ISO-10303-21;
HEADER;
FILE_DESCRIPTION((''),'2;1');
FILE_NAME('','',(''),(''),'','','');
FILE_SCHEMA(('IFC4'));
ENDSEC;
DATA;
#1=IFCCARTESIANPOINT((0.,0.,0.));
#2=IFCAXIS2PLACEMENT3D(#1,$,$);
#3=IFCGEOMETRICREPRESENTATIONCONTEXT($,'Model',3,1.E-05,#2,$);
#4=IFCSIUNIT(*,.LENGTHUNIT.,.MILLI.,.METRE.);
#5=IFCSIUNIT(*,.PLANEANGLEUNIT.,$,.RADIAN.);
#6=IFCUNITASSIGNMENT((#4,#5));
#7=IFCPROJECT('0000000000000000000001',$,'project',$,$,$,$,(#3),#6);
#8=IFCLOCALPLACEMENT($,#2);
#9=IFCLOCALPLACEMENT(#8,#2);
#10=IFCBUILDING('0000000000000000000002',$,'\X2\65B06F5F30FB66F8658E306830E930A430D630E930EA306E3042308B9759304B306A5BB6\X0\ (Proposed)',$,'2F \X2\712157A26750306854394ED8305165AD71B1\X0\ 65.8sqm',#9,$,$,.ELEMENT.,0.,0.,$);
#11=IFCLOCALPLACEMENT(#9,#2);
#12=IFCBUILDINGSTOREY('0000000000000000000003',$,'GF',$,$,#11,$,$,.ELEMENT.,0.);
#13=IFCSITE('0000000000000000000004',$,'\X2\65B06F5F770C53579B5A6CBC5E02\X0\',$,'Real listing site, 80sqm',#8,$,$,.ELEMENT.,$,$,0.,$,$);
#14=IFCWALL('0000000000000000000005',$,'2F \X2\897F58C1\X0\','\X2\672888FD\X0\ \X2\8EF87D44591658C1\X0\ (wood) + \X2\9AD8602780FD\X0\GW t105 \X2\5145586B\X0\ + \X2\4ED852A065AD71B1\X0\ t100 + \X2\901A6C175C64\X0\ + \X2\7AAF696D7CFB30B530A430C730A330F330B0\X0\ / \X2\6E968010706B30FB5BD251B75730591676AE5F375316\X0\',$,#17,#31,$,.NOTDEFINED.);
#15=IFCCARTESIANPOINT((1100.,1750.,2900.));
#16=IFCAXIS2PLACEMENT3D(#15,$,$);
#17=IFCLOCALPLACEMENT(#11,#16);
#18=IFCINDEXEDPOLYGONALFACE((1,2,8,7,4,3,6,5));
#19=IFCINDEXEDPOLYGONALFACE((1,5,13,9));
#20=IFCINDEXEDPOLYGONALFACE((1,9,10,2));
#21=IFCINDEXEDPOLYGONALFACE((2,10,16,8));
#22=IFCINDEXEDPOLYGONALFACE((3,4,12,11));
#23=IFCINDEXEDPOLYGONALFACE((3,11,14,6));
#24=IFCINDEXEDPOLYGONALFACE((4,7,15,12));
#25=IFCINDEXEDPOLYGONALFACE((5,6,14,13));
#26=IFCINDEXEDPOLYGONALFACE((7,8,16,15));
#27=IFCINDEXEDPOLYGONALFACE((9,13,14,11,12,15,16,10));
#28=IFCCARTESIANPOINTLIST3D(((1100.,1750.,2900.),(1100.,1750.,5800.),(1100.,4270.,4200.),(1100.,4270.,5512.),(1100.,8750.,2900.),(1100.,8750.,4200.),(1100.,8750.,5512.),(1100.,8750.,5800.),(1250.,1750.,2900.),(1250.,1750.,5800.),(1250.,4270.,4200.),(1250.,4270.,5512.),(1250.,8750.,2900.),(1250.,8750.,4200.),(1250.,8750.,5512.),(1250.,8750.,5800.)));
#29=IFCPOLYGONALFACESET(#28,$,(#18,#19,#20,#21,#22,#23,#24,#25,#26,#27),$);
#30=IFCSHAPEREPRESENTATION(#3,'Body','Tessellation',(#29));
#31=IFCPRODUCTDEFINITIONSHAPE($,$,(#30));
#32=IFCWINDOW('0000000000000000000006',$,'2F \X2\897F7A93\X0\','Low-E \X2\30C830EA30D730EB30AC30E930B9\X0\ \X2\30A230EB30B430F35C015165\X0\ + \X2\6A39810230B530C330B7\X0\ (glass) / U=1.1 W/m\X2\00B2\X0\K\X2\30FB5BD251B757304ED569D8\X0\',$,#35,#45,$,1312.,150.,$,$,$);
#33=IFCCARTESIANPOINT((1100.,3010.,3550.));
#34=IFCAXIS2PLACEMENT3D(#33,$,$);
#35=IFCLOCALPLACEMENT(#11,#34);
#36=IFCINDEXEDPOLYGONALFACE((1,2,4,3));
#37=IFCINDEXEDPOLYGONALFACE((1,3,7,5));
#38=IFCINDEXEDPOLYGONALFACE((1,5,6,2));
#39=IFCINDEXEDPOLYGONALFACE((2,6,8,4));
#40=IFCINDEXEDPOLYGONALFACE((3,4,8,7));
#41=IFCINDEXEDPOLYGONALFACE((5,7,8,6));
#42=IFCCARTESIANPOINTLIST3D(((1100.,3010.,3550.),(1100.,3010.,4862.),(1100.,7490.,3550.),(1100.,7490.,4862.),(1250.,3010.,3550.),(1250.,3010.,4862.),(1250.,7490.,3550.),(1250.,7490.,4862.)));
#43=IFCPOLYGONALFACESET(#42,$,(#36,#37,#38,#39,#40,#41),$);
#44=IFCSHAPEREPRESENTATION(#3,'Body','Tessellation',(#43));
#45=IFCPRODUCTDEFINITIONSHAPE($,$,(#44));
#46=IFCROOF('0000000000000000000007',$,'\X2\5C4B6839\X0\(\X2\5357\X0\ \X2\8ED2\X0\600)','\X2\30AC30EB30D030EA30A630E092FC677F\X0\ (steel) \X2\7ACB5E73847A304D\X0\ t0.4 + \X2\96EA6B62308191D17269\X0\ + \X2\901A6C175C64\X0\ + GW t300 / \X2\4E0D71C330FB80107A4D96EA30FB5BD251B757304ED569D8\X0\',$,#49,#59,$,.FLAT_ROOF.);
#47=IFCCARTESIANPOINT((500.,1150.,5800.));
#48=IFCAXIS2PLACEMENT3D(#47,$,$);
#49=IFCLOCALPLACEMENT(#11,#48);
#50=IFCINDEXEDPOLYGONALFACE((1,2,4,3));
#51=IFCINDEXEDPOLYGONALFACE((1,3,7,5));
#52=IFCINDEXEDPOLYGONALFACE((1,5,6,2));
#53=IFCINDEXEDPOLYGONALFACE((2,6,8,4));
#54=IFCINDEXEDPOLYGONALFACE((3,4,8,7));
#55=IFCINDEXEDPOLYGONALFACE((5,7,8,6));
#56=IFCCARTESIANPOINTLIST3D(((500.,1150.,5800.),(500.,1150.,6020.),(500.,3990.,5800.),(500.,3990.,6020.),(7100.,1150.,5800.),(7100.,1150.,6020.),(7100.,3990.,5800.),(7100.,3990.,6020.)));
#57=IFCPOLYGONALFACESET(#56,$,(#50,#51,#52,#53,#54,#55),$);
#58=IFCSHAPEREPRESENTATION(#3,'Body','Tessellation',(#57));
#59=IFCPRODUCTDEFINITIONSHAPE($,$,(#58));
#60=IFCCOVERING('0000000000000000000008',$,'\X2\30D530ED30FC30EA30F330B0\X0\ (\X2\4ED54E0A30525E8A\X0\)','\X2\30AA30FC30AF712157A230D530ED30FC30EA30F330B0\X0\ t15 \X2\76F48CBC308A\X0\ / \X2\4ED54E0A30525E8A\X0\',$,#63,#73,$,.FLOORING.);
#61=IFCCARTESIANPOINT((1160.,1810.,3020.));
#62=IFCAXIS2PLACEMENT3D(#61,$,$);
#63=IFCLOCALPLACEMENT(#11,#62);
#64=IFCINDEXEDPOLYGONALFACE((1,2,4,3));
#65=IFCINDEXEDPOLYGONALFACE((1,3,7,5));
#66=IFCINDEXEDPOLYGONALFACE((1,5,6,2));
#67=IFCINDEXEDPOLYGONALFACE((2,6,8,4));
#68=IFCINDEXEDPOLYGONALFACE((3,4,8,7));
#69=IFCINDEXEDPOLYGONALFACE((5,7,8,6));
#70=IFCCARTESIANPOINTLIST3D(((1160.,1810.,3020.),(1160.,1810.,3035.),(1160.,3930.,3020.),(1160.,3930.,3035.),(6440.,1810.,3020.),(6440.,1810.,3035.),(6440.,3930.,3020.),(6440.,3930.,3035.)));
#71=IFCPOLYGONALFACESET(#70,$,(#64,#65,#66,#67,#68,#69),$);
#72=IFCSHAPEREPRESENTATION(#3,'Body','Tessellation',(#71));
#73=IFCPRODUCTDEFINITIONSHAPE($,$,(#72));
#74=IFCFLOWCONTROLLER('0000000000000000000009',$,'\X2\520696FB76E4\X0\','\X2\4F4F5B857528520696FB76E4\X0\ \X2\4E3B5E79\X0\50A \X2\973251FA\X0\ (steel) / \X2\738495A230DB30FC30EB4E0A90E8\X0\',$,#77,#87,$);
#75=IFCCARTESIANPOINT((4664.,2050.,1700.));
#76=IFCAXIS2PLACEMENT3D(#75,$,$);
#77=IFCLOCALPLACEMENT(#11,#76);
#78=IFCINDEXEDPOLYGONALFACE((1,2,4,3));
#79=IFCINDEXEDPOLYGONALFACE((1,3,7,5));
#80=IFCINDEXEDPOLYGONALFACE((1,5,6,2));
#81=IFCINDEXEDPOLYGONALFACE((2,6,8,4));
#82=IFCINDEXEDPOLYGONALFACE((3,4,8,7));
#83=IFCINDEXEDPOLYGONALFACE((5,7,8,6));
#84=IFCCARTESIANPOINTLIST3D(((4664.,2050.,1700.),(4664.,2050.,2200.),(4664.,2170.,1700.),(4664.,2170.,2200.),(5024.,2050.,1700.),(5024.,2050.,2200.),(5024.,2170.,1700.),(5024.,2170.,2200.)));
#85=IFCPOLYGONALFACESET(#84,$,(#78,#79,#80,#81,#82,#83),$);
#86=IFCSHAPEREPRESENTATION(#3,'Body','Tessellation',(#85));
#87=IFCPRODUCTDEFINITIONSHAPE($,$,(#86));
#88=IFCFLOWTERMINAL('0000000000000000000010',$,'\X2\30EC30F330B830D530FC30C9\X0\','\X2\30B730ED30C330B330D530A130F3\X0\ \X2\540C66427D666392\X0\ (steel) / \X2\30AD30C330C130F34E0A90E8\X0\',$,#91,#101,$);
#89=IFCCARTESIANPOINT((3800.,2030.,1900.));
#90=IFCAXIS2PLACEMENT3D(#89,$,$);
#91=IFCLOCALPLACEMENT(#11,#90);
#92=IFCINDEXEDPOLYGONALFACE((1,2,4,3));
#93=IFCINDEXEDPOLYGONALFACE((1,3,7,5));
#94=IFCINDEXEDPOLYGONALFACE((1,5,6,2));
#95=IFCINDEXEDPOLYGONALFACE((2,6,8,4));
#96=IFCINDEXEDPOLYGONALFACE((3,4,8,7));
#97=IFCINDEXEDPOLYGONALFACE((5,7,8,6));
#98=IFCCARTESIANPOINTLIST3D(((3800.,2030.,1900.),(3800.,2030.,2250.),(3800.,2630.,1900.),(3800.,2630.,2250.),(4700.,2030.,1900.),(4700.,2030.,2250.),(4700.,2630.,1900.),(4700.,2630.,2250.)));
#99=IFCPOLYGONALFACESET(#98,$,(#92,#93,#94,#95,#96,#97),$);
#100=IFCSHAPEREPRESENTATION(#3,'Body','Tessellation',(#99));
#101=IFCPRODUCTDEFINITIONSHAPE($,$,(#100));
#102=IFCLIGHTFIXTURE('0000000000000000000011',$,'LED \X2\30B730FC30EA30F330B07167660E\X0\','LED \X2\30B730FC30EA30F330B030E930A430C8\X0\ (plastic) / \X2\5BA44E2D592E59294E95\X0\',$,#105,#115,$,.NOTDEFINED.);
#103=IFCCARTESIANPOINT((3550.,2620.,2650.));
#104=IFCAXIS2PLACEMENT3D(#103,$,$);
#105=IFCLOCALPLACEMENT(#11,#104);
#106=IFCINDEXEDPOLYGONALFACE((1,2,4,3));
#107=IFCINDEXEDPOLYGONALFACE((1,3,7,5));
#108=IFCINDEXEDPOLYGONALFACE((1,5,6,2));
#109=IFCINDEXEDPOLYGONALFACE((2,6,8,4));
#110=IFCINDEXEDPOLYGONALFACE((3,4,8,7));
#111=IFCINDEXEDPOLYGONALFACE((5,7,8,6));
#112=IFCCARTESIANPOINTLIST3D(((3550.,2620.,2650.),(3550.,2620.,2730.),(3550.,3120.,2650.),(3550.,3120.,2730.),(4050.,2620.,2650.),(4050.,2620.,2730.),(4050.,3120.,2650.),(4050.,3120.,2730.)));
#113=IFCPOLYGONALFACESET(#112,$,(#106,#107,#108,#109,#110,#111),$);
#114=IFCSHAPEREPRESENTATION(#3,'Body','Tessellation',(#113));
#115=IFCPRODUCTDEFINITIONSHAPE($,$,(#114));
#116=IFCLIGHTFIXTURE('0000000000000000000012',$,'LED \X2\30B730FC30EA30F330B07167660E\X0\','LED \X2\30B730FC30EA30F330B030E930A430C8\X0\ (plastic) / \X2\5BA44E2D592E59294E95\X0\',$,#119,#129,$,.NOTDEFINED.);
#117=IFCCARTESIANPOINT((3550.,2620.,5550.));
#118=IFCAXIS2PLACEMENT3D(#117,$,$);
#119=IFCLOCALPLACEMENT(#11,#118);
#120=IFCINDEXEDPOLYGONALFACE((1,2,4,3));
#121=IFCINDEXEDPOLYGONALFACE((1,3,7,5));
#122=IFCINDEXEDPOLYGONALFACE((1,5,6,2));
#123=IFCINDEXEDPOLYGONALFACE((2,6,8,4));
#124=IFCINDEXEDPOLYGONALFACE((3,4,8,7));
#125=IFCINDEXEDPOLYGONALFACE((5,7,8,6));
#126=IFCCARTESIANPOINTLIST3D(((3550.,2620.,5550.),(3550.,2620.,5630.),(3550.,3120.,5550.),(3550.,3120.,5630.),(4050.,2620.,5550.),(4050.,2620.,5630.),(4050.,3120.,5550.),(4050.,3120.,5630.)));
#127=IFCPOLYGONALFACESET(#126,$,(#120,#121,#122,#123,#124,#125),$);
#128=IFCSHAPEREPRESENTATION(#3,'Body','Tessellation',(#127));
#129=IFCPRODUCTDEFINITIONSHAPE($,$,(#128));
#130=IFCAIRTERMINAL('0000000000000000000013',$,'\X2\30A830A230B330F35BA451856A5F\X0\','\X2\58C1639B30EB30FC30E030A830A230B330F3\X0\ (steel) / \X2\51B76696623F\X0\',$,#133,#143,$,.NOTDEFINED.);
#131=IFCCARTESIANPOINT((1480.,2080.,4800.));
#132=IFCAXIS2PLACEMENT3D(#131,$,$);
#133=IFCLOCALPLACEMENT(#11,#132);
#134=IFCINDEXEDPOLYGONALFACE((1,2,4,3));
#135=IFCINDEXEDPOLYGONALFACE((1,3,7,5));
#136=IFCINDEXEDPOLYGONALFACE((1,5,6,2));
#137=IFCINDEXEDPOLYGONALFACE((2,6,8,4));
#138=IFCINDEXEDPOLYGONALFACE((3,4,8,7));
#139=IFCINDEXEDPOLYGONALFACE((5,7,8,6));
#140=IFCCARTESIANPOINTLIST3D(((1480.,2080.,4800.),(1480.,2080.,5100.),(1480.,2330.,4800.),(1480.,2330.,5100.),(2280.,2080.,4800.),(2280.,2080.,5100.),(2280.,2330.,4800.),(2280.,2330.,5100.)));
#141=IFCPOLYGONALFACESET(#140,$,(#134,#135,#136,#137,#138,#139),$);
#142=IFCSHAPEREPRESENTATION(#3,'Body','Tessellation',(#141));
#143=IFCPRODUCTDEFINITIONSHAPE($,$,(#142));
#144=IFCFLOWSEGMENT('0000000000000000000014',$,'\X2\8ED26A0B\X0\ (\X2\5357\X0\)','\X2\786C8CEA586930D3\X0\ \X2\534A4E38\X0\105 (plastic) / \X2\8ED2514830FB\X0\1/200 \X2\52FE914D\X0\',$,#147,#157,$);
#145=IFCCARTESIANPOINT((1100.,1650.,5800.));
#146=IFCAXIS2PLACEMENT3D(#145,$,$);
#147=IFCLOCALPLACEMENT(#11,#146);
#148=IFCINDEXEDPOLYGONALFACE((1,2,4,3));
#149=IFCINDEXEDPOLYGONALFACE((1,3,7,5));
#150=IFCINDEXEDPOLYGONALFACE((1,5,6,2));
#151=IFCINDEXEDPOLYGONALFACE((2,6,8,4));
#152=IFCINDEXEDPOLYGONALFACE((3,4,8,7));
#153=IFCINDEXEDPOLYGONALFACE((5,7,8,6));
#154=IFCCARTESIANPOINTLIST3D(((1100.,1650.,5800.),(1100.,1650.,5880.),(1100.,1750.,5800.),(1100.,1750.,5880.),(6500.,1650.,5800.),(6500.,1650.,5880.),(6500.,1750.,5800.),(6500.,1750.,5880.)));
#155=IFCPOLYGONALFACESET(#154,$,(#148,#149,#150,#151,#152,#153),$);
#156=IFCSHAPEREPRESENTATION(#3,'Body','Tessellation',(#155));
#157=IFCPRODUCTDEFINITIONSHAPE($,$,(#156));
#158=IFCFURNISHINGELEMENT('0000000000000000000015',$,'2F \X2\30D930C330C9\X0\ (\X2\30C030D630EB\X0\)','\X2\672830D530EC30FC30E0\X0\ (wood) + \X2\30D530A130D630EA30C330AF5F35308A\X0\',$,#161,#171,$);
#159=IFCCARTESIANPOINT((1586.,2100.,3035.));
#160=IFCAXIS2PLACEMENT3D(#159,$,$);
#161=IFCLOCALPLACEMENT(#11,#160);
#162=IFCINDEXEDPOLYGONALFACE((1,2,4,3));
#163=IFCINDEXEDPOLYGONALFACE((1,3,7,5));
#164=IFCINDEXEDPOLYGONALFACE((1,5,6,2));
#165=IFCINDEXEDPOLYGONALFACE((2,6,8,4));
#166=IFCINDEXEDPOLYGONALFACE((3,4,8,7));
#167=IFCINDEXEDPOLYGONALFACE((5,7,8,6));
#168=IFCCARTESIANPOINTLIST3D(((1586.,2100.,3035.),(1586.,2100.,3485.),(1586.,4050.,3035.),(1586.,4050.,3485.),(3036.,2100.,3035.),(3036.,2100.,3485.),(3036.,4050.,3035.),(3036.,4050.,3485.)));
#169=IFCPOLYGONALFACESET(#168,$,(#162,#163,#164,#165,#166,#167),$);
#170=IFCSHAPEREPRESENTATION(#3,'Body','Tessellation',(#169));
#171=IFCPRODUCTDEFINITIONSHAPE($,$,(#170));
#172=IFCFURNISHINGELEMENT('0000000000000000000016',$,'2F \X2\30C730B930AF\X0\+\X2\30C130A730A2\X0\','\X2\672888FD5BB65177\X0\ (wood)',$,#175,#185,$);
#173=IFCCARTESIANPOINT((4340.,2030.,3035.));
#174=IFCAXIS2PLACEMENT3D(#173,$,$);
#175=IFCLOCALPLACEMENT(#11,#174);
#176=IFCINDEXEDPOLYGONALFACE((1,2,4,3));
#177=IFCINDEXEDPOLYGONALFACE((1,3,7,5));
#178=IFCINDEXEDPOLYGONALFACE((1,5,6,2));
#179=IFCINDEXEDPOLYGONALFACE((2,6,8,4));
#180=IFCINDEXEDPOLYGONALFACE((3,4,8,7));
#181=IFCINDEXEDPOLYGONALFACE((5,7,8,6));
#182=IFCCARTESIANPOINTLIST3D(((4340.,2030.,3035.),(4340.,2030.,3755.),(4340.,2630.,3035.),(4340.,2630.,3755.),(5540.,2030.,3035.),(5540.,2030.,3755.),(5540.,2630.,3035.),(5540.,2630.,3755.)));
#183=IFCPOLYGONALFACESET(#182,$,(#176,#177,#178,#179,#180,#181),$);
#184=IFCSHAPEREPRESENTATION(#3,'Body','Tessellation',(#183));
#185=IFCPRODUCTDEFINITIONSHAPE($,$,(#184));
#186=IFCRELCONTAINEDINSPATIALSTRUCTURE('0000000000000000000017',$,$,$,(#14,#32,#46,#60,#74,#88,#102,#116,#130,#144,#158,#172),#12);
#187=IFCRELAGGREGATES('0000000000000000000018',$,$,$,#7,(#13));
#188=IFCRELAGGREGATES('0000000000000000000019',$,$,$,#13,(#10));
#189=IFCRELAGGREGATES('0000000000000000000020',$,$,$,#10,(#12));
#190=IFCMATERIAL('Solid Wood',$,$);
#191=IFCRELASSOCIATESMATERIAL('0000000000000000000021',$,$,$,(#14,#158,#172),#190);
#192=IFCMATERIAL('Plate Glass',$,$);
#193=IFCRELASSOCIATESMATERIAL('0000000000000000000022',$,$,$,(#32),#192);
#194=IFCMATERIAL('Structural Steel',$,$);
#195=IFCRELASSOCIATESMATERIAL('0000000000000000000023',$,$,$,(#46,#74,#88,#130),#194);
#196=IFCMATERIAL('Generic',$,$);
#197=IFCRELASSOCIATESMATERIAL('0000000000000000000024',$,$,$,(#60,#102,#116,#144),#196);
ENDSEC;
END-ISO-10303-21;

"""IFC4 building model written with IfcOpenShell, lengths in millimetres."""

from ifc_helpers import new_model, si_unit, frame, frame_2d, origin, place, context, project, spatial, rectangle, extrude, material, element, fill, save


model = new_model("IFC4")

# Units and contexts
model_context = context("Model", 3, precision=1e-05, world=origin())
ifc_project = project(units=[si_unit("LENGTHUNIT", "METRE", prefix="MILLI"), si_unit("PLANEANGLEUNIT", "RADIAN")], contexts=[model_context])

# Site, building, storey
site_placement = place(None, origin())
site = spatial("IfcSite", under=ifc_project, at=site_placement, Name="新潟県南魚沼市", ObjectType="Real listing site, 80sqm", CompositionType="ELEMENT", RefElevation=0.0)
building_placement = place(site_placement, origin())
building = spatial("IfcBuilding", under=site, at=building_placement, Name="新潟・書斎とライブラリのある静かな家 (Proposed)", ObjectType="2F 無垢材と吹付け断熱 65.8sqm", CompositionType="ELEMENT", ElevationOfRefHeight=0.0, ElevationOfTerrain=0.0)
storey_placement = place(building_placement, origin())
storey = spatial("IfcBuildingStorey", under=building, at=storey_placement, Name="GF", CompositionType="ELEMENT", Elevation=0.0)

# Shared definitions
ifc_material_1 = material(Name="Solid Wood")

# Wall, opening, window
ifc_material_2 = material(Name="Plate Glass")
wall_1_placement = place(storey_placement, frame((1100.0, 1750.0, 2900.0)))
wall_1 = element("IfcWall", 1, at=wall_1_placement, inside=storey, material=ifc_material_1, Name="2F 西壁", Description="木製 軸組外壁 (wood) + 高性能GW t105 充填 + 付加断熱 t100 + 通気層 + 窯業系サイディング / 準耐火・寒冷地外皮強化", PredefinedType="NOTDEFINED", context=model_context, shape_type="SweptSolid", body=[
    extrude(rectangle(XDim=150.0, YDim=7000.0, at=frame_2d((75.0, 3500.0))), frame((1100.0, 1750.0, 2900.0)), (0.0, 0.0, 1.0), 2900.0),
])
opening_1_placement = place(storey_placement, frame((1100.0, 3010.0, 3550.0)))
opening_1 = element("IfcOpeningElement", 2, at=opening_1_placement, cuts=wall_1, PredefinedType="NOTDEFINED", context=model_context, shape_type="SweptSolid", body=[
    extrude(rectangle(XDim=150.0, YDim=4480.0, at=frame_2d((75.0, 2240.0))), frame((1100.0, 3010.0, 3550.0)), (0.0, 0.0, 1.0), 1312.0),
])
window_1_placement = place(storey_placement, frame((1100.0, 3010.0, 3550.0)))
window_1 = element("IfcWindow", 3, at=window_1_placement, inside=storey, material=ifc_material_2, Name="2F 西窓", Description="Low-E トリプルガラス アルゴン封入 + 樹脂サッシ (glass) / U=1.1 W/m²K・寒冷地仕様", OverallHeight=1312.0, OverallWidth=150.0, context=model_context, shape_type="SweptSolid", body=[
    extrude(rectangle(XDim=150.0, YDim=4480.0, at=frame_2d((75.0, 2240.0))), frame((1100.0, 3010.0, 3550.0)), (0.0, 0.0, 1.0), 1312.0),
])
fill(opening_1, window_1)

# Roof
ifc_material_3 = material(Name="Structural Steel")
for number, where, name in (
    (4, (500.0, 1150.0, 5800.0), "屋根(南 軒600)"),
):
    element("IfcRoof", number, at=place(storey_placement, frame(where)), inside=storey, material=ifc_material_3, Name=name, Description="ガルバリウム鋼板 (steel) 立平葺き t0.4 + 雪止め金物 + 通気層 + GW t300 / 不燃・耐積雪・寒冷地仕様", PredefinedType="FLAT_ROOF", context=model_context, shape_type="SweptSolid", body=[
        extrude(rectangle(XDim=6600.0, YDim=2840.0, at=frame_2d((3300.0, 1420.0))), frame((500.0, 1150.0, 5800.0)), (0.0, 0.0, 1.0), 220.0),
    ])

# Covering
ifc_material_4 = material(Name="Generic")
covering_placement = place(storey_placement, frame((1160.0, 1810.0, 3020.0)))
element("IfcCovering", 5, at=covering_placement, inside=storey, material=ifc_material_4, Name="フローリング (仕上げ床)", Description="オーク無垢フローリング t15 直貼り / 仕上げ床", PredefinedType="FLOORING", context=model_context, shape_type="SweptSolid", body=[
    extrude(rectangle(XDim=5280.0, YDim=2120.0, at=frame_2d((2640.0, 1060.0))), frame((1160.0, 1810.0, 3020.0)), (0.0, 0.0, 1.0), 15.0),
])

# Flow controller
flow_controller_placement = place(storey_placement, frame((4664.0, 2050.0, 1700.0)))
element("IfcFlowController", 6, at=flow_controller_placement, inside=storey, material=ifc_material_3, Name="分電盤", Description="住宅用分電盤 主幹50A 露出 (steel) / 玄関ホール上部", context=model_context, shape_type="SweptSolid", body=[
    extrude(rectangle(XDim=360.0, YDim=120.0, at=frame_2d((180.0, 60.0))), frame((4664.0, 2050.0, 1700.0)), (0.0, 0.0, 1.0), 500.0),
])

# Flow terminal
flow_terminal_placement = place(storey_placement, frame((3800.0, 2030.0, 1900.0)))
element("IfcFlowTerminal", 7, at=flow_terminal_placement, inside=storey, material=ifc_material_3, Name="レンジフード", Description="シロッコファン 同時給排 (steel) / キッチン上部", context=model_context, shape_type="SweptSolid", body=[
    extrude(rectangle(XDim=900.0, YDim=600.0, at=frame_2d((450.0, 300.0))), frame((3800.0, 2030.0, 1900.0)), (0.0, 0.0, 1.0), 350.0),
])

# Light fixtures
light_fixture_1_placement = place(storey_placement, frame((3550.0, 2620.0, 2650.0)))
element("IfcLightFixture", 8, at=light_fixture_1_placement, inside=storey, material=ifc_material_4, Name="LED シーリング照明", Description="LED シーリングライト (plastic) / 室中央天井", PredefinedType="NOTDEFINED", context=model_context, shape_type="SweptSolid", body=[
    extrude(rectangle(XDim=500.0, YDim=500.0, at=frame_2d((250.0, 250.0))), frame((3550.0, 2620.0, 2650.0)), (0.0, 0.0, 1.0), 80.0),
])
light_fixture_2_placement = place(storey_placement, frame((3550.0, 2620.0, 5550.0)))
element("IfcLightFixture", 9, at=light_fixture_2_placement, inside=storey, material=ifc_material_4, Name="LED シーリング照明", Description="LED シーリングライト (plastic) / 室中央天井", PredefinedType="NOTDEFINED", context=model_context, shape_type="SweptSolid", body=[
    extrude(rectangle(XDim=500.0, YDim=500.0, at=frame_2d((250.0, 250.0))), frame((3550.0, 2620.0, 5550.0)), (0.0, 0.0, 1.0), 80.0),
])

# Air terminal
air_terminal_placement = place(storey_placement, frame((1480.0, 2080.0, 4800.0)))
element("IfcAirTerminal", 10, at=air_terminal_placement, inside=storey, material=ifc_material_3, Name="エアコン室内機", Description="壁掛ルームエアコン (steel) / 冷暖房", PredefinedType="NOTDEFINED", context=model_context, shape_type="SweptSolid", body=[
    extrude(rectangle(XDim=800.0, YDim=250.0, at=frame_2d((400.0, 125.0))), frame((1480.0, 2080.0, 4800.0)), (0.0, 0.0, 1.0), 300.0),
])

# Flow segment
flow_segment_placement = place(storey_placement, frame((1100.0, 1650.0, 5800.0)))
element("IfcFlowSegment", 11, at=flow_segment_placement, inside=storey, material=ifc_material_4, Name="軒樋 (南)", Description="硬質塩ビ 半丸105 (plastic) / 軒先・1/200 勾配", context=model_context, shape_type="SweptSolid", body=[
    extrude(rectangle(XDim=5400.0, YDim=100.0, at=frame_2d((2700.0, 50.0))), frame((1100.0, 1650.0, 5800.0)), (0.0, 0.0, 1.0), 80.0),
])

# Furnishing elements
furnishing_1_placement = place(storey_placement, frame((1586.0, 2100.0, 3035.0)))
element("IfcFurnishingElement", 12, at=furnishing_1_placement, inside=storey, material=ifc_material_1, Name="2F ベッド (ダブル)", Description="木フレーム (wood) + ファブリック張り", context=model_context, shape_type="SweptSolid", body=[
    extrude(rectangle(XDim=1450.0, YDim=1950.0, at=frame_2d((725.0, 975.0))), frame((1586.0, 2100.0, 3035.0)), (0.0, 0.0, 1.0), 450.0),
])
furnishing_2_placement = place(storey_placement, frame((4340.0, 2030.0, 3035.0)))
element("IfcFurnishingElement", 13, at=furnishing_2_placement, inside=storey, material=ifc_material_1, Name="2F デスク+チェア", Description="木製家具 (wood)", context=model_context, shape_type="SweptSolid", body=[
    extrude(rectangle(XDim=1200.0, YDim=600.0, at=frame_2d((600.0, 300.0))), frame((4340.0, 2030.0, 3035.0)), (0.0, 0.0, 1.0), 720.0),
])

save(model, "model.ifc")
